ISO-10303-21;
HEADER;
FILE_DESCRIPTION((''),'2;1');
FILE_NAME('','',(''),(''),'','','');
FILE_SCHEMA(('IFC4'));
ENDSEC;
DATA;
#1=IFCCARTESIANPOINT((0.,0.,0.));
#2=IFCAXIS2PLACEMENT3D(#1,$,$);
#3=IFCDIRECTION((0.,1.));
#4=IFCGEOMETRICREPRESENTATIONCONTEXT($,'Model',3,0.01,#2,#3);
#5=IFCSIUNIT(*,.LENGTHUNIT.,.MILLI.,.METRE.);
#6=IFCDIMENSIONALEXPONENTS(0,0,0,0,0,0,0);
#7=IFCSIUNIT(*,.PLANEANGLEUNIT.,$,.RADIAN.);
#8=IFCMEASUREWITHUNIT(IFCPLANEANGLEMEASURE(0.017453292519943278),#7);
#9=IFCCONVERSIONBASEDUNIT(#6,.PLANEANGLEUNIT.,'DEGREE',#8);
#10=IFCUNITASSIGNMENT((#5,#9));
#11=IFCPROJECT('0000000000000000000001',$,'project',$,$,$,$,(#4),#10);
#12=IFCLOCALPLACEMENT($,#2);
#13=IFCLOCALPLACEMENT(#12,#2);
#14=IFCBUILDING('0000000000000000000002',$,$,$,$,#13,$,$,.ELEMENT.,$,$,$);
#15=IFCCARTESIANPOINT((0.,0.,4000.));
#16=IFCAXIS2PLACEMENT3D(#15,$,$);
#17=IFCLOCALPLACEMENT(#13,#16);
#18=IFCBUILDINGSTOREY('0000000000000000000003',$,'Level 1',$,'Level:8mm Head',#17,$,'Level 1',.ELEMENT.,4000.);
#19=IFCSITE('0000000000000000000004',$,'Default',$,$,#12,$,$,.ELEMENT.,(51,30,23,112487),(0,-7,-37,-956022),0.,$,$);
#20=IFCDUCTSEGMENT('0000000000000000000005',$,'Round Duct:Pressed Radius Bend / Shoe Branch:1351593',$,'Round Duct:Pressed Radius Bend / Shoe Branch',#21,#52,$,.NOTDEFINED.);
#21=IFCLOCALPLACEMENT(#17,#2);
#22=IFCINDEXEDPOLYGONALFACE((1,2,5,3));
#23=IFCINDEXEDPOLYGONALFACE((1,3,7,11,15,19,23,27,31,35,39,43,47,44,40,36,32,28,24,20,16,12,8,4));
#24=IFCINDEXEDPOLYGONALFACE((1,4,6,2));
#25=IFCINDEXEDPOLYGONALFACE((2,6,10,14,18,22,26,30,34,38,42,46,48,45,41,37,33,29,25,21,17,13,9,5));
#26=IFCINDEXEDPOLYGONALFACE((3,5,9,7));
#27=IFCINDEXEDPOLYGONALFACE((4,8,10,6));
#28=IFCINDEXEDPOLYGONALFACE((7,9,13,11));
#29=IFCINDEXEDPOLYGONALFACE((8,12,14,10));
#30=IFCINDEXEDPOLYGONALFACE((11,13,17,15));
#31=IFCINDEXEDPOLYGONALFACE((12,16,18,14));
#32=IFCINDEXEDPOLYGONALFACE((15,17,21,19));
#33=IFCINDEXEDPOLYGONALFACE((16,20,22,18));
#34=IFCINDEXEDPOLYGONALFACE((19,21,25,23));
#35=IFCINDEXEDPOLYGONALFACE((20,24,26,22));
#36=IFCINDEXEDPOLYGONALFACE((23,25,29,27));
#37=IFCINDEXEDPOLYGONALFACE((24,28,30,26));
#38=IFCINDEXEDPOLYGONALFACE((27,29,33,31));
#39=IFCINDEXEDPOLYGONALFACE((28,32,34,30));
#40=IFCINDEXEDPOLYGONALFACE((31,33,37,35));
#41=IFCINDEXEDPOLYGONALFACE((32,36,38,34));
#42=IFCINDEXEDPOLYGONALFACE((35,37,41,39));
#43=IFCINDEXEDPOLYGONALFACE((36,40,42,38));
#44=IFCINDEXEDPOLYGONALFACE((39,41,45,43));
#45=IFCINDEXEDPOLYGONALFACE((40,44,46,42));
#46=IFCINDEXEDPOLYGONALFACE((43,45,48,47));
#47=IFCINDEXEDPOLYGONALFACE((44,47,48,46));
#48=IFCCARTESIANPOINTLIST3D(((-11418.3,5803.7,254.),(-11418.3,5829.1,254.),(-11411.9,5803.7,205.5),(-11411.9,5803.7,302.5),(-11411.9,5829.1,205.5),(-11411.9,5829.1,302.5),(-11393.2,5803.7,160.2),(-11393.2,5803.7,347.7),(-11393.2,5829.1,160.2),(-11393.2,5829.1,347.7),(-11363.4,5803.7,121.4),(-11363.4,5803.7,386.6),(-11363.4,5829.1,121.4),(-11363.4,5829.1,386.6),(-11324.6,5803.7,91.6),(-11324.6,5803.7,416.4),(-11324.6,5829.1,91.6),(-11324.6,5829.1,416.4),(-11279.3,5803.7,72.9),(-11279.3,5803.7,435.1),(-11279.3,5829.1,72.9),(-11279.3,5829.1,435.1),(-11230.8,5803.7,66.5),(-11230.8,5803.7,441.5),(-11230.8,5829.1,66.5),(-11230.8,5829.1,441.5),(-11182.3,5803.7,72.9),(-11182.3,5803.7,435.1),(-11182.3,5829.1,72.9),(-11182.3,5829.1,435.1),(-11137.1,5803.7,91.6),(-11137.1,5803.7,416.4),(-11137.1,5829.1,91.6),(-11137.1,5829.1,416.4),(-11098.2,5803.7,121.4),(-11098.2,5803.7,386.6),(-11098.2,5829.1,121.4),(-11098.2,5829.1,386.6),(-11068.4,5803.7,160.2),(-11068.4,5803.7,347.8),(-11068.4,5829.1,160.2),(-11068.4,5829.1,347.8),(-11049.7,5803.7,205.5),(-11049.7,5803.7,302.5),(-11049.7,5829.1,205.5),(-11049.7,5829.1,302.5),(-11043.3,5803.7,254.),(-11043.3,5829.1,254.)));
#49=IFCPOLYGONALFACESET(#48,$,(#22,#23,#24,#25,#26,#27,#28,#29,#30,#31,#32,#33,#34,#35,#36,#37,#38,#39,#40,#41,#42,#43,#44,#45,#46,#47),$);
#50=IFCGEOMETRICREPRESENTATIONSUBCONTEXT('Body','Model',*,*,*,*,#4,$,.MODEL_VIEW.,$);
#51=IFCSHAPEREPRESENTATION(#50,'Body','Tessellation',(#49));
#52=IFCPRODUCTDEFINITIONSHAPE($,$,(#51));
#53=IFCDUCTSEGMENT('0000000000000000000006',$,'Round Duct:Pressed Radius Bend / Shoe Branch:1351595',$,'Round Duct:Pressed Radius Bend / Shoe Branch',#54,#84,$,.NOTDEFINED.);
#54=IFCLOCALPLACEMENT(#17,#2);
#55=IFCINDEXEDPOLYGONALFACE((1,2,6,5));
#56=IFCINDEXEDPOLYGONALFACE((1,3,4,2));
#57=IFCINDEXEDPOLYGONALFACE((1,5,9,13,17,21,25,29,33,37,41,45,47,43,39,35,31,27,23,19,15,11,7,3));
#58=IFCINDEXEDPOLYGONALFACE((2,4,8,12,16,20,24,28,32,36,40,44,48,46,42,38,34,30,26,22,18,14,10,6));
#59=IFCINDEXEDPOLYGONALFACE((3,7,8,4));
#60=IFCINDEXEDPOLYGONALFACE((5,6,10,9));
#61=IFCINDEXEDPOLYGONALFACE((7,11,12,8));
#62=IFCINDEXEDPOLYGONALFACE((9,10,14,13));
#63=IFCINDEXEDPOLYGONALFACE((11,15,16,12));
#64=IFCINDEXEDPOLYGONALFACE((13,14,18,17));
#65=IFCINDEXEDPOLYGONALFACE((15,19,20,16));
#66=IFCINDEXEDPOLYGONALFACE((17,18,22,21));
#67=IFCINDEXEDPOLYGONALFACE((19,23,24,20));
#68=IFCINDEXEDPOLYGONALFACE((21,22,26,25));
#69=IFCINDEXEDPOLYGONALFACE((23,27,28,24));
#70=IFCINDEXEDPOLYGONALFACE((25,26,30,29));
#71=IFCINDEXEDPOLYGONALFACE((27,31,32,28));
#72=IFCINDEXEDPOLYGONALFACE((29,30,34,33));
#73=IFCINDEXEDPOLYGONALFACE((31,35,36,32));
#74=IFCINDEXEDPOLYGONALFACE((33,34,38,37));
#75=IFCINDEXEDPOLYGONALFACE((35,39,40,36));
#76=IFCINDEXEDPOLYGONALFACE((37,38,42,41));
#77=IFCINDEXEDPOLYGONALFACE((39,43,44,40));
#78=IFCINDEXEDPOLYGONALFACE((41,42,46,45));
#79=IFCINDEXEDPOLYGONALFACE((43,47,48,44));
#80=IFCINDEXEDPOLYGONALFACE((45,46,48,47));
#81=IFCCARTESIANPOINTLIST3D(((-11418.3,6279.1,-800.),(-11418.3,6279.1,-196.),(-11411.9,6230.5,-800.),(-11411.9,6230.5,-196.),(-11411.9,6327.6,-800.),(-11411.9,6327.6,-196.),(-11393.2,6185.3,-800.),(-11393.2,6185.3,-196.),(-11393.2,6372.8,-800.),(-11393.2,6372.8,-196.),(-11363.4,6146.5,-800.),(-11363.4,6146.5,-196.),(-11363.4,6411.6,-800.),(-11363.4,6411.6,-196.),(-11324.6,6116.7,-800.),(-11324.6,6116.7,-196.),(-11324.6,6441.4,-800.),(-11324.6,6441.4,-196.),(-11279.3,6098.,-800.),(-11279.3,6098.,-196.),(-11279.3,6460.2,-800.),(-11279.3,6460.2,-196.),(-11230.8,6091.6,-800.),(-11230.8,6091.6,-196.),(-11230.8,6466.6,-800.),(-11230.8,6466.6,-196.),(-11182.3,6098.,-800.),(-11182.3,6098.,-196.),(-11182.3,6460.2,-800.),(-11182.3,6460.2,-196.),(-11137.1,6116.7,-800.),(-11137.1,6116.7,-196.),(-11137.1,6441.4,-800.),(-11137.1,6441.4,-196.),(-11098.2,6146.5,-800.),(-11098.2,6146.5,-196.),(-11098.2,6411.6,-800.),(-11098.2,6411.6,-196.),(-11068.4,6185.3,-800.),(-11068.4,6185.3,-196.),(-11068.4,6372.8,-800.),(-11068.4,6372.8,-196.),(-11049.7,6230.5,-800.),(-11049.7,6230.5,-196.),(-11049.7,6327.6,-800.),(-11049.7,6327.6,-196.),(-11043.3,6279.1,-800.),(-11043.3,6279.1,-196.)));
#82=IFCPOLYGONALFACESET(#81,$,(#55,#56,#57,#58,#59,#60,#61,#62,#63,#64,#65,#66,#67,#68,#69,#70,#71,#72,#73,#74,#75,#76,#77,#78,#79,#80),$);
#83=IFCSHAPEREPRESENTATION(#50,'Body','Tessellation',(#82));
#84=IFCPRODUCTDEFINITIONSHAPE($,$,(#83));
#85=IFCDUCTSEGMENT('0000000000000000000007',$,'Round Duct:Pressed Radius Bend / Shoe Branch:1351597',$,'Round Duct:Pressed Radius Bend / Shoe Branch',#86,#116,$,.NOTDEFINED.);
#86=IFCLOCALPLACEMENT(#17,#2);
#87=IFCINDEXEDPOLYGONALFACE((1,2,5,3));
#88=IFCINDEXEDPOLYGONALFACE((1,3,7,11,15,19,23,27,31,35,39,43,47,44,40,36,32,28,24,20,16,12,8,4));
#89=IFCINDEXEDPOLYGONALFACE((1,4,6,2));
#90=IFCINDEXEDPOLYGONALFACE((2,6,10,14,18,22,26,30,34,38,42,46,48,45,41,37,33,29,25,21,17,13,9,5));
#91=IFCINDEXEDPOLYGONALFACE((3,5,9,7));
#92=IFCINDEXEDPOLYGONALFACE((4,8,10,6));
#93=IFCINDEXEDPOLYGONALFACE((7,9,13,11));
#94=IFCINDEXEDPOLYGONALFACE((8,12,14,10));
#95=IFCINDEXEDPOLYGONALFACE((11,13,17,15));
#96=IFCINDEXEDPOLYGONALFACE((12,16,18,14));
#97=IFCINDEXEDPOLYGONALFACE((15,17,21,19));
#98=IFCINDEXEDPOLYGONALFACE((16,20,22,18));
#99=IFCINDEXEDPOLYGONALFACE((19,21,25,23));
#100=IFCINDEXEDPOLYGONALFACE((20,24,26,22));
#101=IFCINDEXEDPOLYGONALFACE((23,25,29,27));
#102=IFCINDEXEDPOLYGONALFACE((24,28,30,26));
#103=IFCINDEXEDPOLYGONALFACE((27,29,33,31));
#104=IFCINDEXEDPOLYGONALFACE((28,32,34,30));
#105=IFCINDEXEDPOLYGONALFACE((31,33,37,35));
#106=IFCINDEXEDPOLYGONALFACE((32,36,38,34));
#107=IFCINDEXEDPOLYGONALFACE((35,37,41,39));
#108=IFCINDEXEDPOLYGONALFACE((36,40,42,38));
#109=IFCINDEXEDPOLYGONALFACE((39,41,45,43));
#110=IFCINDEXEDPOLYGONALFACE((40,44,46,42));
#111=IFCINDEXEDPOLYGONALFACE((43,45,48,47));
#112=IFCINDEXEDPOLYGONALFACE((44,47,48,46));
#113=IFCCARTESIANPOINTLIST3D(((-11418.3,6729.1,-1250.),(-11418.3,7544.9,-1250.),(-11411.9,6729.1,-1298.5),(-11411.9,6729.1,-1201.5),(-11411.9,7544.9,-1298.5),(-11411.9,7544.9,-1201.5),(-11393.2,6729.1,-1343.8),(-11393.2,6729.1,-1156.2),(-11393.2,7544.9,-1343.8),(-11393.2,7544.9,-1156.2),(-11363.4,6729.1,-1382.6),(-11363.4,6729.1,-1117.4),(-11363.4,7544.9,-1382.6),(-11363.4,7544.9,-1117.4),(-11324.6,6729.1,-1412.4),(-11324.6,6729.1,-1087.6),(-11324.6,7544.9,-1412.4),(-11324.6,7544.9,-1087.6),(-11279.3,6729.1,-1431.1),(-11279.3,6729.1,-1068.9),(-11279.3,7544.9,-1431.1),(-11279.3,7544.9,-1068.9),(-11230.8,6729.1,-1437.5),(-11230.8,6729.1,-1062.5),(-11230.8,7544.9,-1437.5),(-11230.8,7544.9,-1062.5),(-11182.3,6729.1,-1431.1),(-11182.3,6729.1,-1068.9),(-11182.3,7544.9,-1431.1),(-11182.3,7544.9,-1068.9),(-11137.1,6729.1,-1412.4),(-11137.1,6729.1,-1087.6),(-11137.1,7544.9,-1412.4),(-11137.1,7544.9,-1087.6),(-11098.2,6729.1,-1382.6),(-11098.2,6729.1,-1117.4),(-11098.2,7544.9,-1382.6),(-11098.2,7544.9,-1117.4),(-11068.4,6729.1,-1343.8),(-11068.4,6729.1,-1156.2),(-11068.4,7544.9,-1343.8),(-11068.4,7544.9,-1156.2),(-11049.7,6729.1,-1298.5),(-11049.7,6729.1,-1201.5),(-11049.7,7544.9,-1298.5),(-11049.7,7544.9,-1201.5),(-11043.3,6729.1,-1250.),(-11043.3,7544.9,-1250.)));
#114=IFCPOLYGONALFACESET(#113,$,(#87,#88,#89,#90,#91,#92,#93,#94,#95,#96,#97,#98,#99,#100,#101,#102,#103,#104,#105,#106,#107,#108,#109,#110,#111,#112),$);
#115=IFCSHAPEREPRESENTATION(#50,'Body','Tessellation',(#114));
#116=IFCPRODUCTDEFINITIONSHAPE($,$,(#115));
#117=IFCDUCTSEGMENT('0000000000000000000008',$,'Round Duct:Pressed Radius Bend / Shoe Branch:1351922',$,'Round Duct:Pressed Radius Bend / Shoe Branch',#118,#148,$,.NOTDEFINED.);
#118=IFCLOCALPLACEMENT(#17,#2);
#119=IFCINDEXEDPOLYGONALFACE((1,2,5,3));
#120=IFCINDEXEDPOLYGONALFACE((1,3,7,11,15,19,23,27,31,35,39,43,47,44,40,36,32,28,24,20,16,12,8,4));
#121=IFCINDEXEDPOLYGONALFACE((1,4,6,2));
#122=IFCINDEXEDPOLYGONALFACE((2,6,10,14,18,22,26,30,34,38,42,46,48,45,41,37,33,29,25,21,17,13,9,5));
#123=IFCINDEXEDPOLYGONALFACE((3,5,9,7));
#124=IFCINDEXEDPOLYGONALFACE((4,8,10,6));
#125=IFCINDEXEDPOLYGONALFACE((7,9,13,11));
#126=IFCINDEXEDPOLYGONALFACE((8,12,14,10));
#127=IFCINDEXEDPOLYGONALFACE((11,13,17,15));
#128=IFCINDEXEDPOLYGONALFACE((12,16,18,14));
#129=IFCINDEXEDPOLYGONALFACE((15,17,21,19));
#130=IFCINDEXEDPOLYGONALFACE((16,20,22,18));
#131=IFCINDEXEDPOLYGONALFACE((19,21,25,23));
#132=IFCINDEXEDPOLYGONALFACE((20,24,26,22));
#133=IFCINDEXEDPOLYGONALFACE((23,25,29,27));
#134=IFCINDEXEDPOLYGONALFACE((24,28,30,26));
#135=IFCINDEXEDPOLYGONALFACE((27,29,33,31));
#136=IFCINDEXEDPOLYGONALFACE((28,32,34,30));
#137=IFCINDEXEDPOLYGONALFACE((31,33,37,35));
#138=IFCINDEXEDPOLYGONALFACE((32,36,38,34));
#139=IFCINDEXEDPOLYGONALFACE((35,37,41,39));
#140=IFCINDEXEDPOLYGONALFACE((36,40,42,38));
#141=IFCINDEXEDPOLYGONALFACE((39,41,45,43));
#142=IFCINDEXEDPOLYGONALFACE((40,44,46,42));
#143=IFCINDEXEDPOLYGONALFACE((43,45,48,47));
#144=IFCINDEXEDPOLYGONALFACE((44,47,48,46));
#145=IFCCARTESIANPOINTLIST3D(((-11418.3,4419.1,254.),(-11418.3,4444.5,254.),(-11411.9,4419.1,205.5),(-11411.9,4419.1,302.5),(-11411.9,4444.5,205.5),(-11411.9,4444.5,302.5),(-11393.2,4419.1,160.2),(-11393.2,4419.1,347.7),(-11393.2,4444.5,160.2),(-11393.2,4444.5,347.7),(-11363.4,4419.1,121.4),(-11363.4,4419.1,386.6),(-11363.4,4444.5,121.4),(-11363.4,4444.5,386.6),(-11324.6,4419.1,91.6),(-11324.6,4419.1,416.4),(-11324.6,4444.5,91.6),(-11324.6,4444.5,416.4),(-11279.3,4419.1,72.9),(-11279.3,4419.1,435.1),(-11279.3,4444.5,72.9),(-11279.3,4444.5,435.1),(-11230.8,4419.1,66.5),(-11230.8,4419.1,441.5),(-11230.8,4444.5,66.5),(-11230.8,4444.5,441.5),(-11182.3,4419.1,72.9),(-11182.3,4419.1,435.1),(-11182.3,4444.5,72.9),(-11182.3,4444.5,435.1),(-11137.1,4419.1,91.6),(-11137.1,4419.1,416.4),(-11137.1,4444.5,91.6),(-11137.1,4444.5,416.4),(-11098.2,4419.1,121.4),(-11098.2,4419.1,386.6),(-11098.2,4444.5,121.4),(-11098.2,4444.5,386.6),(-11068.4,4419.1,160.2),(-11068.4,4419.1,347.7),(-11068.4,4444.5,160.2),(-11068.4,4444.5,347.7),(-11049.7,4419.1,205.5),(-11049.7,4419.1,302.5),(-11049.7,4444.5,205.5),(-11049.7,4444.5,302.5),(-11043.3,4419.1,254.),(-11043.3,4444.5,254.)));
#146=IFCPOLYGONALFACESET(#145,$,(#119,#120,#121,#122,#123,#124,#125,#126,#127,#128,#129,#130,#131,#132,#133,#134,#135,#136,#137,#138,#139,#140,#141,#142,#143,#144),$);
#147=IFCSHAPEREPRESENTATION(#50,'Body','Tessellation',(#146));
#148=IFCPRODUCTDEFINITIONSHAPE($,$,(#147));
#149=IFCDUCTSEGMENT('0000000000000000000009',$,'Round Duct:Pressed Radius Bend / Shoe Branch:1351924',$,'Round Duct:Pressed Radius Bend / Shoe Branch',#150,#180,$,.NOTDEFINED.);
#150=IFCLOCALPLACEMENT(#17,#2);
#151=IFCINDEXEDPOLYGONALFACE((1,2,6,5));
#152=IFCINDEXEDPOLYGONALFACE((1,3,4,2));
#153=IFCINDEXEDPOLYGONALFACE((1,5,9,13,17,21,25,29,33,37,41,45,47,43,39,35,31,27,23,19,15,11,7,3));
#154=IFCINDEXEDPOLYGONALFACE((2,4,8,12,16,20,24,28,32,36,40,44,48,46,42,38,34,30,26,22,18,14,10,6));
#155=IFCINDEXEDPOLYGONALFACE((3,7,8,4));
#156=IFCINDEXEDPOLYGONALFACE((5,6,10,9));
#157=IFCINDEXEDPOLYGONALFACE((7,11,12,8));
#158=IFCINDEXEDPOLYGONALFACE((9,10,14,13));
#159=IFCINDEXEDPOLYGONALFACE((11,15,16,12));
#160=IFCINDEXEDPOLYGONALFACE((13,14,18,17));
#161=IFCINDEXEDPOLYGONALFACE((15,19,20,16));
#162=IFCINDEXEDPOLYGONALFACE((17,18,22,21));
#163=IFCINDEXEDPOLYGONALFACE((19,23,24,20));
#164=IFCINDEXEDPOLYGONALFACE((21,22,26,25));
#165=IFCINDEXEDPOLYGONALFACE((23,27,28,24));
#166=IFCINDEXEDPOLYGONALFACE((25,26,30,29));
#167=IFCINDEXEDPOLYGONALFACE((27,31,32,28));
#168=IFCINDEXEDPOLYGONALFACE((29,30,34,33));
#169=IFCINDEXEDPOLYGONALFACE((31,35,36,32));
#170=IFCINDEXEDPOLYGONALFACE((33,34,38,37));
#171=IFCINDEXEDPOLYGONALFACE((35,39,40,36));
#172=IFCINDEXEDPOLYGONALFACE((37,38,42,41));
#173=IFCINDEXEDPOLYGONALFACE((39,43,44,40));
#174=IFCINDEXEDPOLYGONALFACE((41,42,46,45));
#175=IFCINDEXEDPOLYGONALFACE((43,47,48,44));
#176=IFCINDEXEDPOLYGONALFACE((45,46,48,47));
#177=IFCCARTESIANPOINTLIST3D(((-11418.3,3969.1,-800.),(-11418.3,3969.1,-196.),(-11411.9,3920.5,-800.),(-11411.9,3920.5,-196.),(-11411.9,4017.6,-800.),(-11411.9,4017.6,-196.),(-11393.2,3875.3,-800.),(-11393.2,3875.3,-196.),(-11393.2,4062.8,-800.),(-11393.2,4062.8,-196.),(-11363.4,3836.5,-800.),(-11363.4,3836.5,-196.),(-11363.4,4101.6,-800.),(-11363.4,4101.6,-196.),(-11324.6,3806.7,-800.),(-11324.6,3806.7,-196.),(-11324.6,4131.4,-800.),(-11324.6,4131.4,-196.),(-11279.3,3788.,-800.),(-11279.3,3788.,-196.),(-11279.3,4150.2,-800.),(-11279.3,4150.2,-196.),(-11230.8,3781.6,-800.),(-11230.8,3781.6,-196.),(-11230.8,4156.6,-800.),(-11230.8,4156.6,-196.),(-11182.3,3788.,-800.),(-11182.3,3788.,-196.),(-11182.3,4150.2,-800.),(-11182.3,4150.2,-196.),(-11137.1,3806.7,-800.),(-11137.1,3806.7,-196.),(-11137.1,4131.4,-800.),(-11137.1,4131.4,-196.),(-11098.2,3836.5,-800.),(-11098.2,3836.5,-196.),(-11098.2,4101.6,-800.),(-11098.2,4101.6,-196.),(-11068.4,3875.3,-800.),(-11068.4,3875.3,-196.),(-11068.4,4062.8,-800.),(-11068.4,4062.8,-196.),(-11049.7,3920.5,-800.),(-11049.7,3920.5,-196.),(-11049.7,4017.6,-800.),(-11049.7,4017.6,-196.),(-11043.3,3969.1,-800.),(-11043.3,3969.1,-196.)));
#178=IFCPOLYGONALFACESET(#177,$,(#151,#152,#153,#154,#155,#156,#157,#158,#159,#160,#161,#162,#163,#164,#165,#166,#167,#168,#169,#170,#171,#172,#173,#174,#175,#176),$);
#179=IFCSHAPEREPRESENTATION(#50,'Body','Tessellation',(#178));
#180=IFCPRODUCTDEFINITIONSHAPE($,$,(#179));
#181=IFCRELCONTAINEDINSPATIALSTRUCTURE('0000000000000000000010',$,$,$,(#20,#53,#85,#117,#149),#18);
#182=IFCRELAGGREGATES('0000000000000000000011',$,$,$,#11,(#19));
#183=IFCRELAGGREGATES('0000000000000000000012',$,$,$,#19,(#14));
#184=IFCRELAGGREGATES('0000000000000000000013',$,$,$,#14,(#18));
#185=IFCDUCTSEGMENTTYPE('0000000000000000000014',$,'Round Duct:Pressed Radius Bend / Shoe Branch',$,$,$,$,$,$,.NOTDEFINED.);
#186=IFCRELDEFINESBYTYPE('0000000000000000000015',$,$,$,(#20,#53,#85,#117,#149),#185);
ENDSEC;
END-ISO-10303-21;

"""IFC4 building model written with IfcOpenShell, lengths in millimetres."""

from ifc_helpers import new_model, entity, si_unit, converted_unit, direction, frame, origin, place, context, subcontext, project, spatial, arc, indexed_curve, outline, extrude, type_object, element, save


model = new_model("IFC4")

# Units and contexts
model_context = context("Model", 3, precision=0.01, world=origin(), true_north=direction((0.0, 1.0)))
body_context = subcontext(model_context, "Body", "Model", "MODEL_VIEW")
ifc_project = project(units=[si_unit("LENGTHUNIT", "METRE", prefix="MILLI"), converted_unit("PLANEANGLEUNIT", "DEGREE", entity("IfcPlaneAngleMeasure", 0.017453292519943278), si_unit("PLANEANGLEUNIT", "RADIAN"), dimensions=[0, 0, 0, 0, 0, 0, 0])], contexts=[model_context])

# Site, building, storey
site_placement = place(None, origin())
site = spatial("IfcSite", under=ifc_project, at=site_placement, Name="Default", CompositionType="ELEMENT", RefLatitude=(51, 30, 23, 112487), RefLongitude=(0, -7, -37, -956022), RefElevation=0.0)
building_placement = place(site_placement, origin())
building = spatial("IfcBuilding", under=site, at=building_placement, CompositionType="ELEMENT")
storey_placement = place(building_placement, frame((0.0, 0.0, 4000.0)))
storey = spatial("IfcBuildingStorey", under=building, at=storey_placement, Name="Level 1", ObjectType="Level:8mm Head", LongName="Level 1", CompositionType="ELEMENT", Elevation=4000.0)

# Duct segments
duct_segment_type = type_object("IfcDuctSegmentType", Name="Round Duct:Pressed Radius Bend / Shoe Branch", PredefinedType="NOTDEFINED")
duct_segment_1_placement = place(storey_placement, origin())
element("IfcDuctSegment", 1, at=duct_segment_1_placement, inside=storey, type_object=duct_segment_type, Name="Round Duct:Pressed Radius Bend / Shoe Branch:1351593", ObjectType="Round Duct:Pressed Radius Bend / Shoe Branch", PredefinedType="NOTDEFINED", context=body_context, shape_type="SweptSolid", body=[
    extrude(outline(indexed_curve([(187.5, 0.0), (132.6, 132.6), (0.0, 187.5), (-132.6, 132.6), (-187.5, 0.0), (-132.6, -132.6), (0.0, -187.5), (132.6, -132.6)], segments=[arc(1, 2, 3), arc(3, 4, 5), arc(5, 6, 7), arc(7, 8, 1)], self_intersect=False)), frame((-11230.8, 5803.7, 254.0), z_axis=(0.0, 1.0, 0.0), x_axis=(1.0, 0.0, 0.0)), (0.0, 0.0, 1.0), 25.4),
])
duct_segment_2_placement = place(storey_placement, origin())
element("IfcDuctSegment", 2, at=duct_segment_2_placement, inside=storey, type_object=duct_segment_type, Name="Round Duct:Pressed Radius Bend / Shoe Branch:1351595", ObjectType="Round Duct:Pressed Radius Bend / Shoe Branch", PredefinedType="NOTDEFINED", context=body_context, shape_type="SweptSolid", body=[
    extrude(outline(indexed_curve([(187.5, 0.0), (132.6, 132.6), (0.0, 187.5), (-132.6, 132.6), (-187.5, 0.0), (-132.6, -132.6), (0.0, -187.5), (132.6, -132.6)], segments=[arc(1, 2, 3), arc(3, 4, 5), arc(5, 6, 7), arc(7, 8, 1)], self_intersect=False)), frame((-11230.8, 6279.1, -800.0)), (0.0, 0.0, 1.0), 604.0),
])
duct_segment_3_placement = place(storey_placement, origin())
element("IfcDuctSegment", 3, at=duct_segment_3_placement, inside=storey, type_object=duct_segment_type, Name="Round Duct:Pressed Radius Bend / Shoe Branch:1351597", ObjectType="Round Duct:Pressed Radius Bend / Shoe Branch", PredefinedType="NOTDEFINED", context=body_context, shape_type="SweptSolid", body=[
    extrude(outline(indexed_curve([(187.5, 0.0), (132.6, 132.6), (0.0, 187.5), (-132.6, 132.6), (-187.5, 0.0), (-132.6, -132.6), (0.0, -187.5), (132.6, -132.6)], segments=[arc(1, 2, 3), arc(3, 4, 5), arc(5, 6, 7), arc(7, 8, 1)], self_intersect=False)), frame((-11230.8, 6729.1, -1250.0), z_axis=(0.0, 1.0, 0.0), x_axis=(-1.0, 0.0, 0.0)), (0.0, 0.0, 1.0), 815.8),
])
duct_segment_4_placement = place(storey_placement, origin())
element("IfcDuctSegment", 4, at=duct_segment_4_placement, inside=storey, type_object=duct_segment_type, Name="Round Duct:Pressed Radius Bend / Shoe Branch:1351922", ObjectType="Round Duct:Pressed Radius Bend / Shoe Branch", PredefinedType="NOTDEFINED", context=body_context, shape_type="SweptSolid", body=[
    extrude(outline(indexed_curve([(187.5, 0.0), (132.6, 132.6), (0.0, 187.5), (-132.6, 132.6), (-187.5, 0.0), (-132.6, -132.6), (0.0, -187.5), (132.6, -132.6)], segments=[arc(1, 2, 3), arc(3, 4, 5), arc(5, 6, 7), arc(7, 8, 1)], self_intersect=False)), frame((-11230.8, 4419.1, 254.0), z_axis=(0.0, 1.0, 0.0), x_axis=(-1.0, 0.0, 0.0)), (0.0, 0.0, 1.0), 25.4),
])
duct_segment_5_placement = place(storey_placement, origin())
element("IfcDuctSegment", 5, at=duct_segment_5_placement, inside=storey, type_object=duct_segment_type, Name="Round Duct:Pressed Radius Bend / Shoe Branch:1351924", ObjectType="Round Duct:Pressed Radius Bend / Shoe Branch", PredefinedType="NOTDEFINED", context=body_context, shape_type="SweptSolid", body=[
    extrude(outline(indexed_curve([(187.5, 0.0), (132.6, 132.6), (0.0, 187.5), (-132.6, 132.6), (-187.5, 0.0), (-132.6, -132.6), (0.0, -187.5), (132.6, -132.6)], segments=[arc(1, 2, 3), arc(3, 4, 5), arc(5, 6, 7), arc(7, 8, 1)], self_intersect=False)), frame((-11230.8, 3969.1, -800.0), z_axis=(0.0, 0.0, 1.0), x_axis=(-1.0, 0.0, 0.0)), (0.0, 0.0, 1.0), 604.0),
])

save(model, "model.ifc")
